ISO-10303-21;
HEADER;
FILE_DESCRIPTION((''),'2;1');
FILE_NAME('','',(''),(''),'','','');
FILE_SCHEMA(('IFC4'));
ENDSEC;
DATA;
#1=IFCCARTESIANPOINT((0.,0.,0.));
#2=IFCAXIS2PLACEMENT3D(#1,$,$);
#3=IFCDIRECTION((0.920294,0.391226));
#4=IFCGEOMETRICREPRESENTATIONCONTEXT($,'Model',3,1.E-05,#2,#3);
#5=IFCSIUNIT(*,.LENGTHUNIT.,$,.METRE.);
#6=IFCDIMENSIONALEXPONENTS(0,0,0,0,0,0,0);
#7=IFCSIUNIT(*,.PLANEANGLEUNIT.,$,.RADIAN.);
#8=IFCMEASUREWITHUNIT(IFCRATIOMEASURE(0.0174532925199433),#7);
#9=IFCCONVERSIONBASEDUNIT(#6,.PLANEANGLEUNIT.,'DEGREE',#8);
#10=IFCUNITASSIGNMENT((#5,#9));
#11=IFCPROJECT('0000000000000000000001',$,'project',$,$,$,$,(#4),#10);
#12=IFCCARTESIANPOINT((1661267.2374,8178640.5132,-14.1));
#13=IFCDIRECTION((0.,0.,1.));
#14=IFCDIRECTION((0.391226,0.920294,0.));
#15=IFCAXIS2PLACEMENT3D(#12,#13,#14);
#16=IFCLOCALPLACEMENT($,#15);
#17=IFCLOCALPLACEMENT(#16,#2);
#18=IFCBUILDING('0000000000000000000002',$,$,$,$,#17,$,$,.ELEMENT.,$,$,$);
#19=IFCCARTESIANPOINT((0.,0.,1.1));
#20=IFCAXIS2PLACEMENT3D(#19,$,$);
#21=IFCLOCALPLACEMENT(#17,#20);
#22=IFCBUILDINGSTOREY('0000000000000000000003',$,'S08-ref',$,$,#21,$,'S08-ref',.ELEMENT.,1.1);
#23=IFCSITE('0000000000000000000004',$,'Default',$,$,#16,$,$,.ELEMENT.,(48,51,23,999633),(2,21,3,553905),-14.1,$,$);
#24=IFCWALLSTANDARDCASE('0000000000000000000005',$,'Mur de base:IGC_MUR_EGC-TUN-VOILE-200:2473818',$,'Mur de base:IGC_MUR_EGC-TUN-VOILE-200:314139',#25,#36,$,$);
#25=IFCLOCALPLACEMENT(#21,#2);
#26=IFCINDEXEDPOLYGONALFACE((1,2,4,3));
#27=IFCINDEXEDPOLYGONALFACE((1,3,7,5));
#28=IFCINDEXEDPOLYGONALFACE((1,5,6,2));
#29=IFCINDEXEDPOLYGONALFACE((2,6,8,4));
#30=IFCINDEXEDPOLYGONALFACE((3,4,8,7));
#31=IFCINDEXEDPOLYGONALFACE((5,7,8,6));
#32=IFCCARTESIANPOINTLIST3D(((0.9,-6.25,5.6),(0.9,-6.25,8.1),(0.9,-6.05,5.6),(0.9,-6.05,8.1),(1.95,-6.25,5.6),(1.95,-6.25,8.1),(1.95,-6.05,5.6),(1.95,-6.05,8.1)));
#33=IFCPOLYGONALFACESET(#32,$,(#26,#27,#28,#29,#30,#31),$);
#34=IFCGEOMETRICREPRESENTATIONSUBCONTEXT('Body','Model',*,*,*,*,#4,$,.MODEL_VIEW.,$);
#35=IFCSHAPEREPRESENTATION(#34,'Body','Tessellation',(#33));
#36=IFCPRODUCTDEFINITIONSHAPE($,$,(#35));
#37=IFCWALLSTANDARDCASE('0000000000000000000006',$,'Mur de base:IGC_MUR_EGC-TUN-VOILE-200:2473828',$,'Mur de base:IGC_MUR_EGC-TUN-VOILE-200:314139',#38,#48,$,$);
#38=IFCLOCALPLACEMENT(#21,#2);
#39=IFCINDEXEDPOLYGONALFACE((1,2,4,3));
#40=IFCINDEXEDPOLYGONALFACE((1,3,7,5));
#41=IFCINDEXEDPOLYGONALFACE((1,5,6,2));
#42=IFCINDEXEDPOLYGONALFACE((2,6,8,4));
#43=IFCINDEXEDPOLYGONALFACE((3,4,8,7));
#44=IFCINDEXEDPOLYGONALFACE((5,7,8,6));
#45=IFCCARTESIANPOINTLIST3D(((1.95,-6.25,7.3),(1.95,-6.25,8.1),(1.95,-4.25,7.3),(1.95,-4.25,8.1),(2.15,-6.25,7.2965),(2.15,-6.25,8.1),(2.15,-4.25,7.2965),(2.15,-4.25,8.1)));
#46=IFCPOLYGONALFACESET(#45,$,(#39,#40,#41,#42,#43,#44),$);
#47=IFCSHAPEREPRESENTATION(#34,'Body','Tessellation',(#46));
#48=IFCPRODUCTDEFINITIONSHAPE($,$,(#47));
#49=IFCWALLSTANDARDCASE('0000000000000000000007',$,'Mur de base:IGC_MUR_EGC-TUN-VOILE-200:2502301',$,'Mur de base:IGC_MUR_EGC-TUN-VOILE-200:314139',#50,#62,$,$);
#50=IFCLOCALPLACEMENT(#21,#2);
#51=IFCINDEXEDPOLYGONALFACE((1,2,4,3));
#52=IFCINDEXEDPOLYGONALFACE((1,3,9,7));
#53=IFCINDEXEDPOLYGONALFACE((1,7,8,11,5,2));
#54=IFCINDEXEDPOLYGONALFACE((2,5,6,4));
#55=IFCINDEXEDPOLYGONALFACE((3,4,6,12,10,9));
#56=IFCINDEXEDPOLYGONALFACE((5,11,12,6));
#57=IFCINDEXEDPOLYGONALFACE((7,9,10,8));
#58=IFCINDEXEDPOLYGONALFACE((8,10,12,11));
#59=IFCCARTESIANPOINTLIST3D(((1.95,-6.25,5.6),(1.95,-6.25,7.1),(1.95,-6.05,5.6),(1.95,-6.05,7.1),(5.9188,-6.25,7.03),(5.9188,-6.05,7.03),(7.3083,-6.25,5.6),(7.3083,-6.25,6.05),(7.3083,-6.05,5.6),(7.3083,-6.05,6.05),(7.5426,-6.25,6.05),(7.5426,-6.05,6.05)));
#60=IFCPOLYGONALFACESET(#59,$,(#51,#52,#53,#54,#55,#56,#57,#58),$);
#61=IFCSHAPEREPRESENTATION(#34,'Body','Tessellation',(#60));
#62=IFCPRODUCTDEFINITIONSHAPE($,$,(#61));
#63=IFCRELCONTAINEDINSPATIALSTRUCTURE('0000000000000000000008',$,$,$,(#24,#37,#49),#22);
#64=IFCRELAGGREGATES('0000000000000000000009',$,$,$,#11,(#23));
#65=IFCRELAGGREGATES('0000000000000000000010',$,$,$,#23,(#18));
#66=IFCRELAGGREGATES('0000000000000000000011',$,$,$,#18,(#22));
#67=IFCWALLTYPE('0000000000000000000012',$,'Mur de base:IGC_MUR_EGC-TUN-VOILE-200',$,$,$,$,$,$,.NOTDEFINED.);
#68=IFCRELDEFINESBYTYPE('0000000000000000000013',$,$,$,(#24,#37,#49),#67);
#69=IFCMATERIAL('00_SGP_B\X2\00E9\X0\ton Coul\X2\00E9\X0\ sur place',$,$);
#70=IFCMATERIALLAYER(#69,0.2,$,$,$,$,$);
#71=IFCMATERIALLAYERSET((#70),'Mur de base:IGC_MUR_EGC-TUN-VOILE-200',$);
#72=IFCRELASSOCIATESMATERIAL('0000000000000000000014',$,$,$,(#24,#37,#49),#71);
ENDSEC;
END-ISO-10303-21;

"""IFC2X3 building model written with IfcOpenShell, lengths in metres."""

from ifc_helpers import new_model, entity, si_unit, converted_unit, direction, frame, frame_2d, origin, place, context, subcontext, project, spatial, polyline, rectangle, extrude, clip, halfspace, bounded_halfspace, material, layer, layer_set, layer_usage, type_object, element, save


model = new_model("IFC2X3")

# Units and contexts
model_context = context("Model", 3, precision=1e-05, world=origin(), true_north=direction((0.920294, 0.391226)))
body_context = subcontext(model_context, "Body", "Model", "MODEL_VIEW")
ifc_project = project(units=[si_unit("LENGTHUNIT", "METRE"), converted_unit("PLANEANGLEUNIT", "DEGREE", entity("IfcRatioMeasure", 0.0174532925199433), si_unit("PLANEANGLEUNIT", "RADIAN"), dimensions=[0, 0, 0, 0, 0, 0, 0])], contexts=[model_context])

# Site, building, storey
site_placement = place(None, frame((1661267.2374, 8178640.5132, -14.1), z_axis=(0.0, 0.0, 1.0), x_axis=(0.391226, 0.920294, 0.0)))
site = spatial("IfcSite", under=ifc_project, at=site_placement, Name="Default", CompositionType="ELEMENT", RefLatitude=(48, 51, 23, 999633), RefLongitude=(2, 21, 3, 553905), RefElevation=-14.1)
building_placement = place(site_placement, origin())
building = spatial("IfcBuilding", under=site, at=building_placement, CompositionType="ELEMENT")
storey_placement = place(building_placement, frame((0.0, 0.0, 1.1)))
storey = spatial("IfcBuildingStorey", under=building, at=storey_placement, Name="S08-ref", LongName="S08-ref", CompositionType="ELEMENT", Elevation=1.1)

# Walls
ifc_material_1 = material(Name="00_SGP_Béton Coulé sur place")
ifc_layer_1 = layer(ifc_material_1, 0.2)
ifc_layer_set_1 = layer_set([ifc_layer_1], Name="Mur de base:IGC_MUR_EGC-TUN-VOILE-200")
ifc_layer_usage_1 = layer_usage(ifc_layer_set_1, "AXIS2", "NEGATIVE", 0.1)
wall_type_1 = type_object("IfcWallType", Name="Mur de base:IGC_MUR_EGC-TUN-VOILE-200", PredefinedType="NOTDEFINED")
wall_1_placement = place(storey_placement, frame((0.9, -6.15, 5.6)))
element("IfcWallStandardCase", 1, at=wall_1_placement, inside=storey, type_object=wall_type_1, material=ifc_layer_usage_1, Name="Mur de base:IGC_MUR_EGC-TUN-VOILE-200:2473818", ObjectType="Mur de base:IGC_MUR_EGC-TUN-VOILE-200:314139", context=body_context, shape_type="SweptSolid", body=[
    extrude(rectangle(XDim=1.05, YDim=0.2, at=frame_2d((0.525, 0.0), x_axis=(-1.0, 0.0))), origin(), (0.0, 0.0, 1.0), 2.5),
])
ifc_layer_usage_2 = layer_usage(ifc_layer_set_1, "AXIS2", "NEGATIVE", 0.1)
wall_2_placement = place(storey_placement, frame((2.05, -6.25, 7.2965), z_axis=(0.0, 0.0, 1.0), x_axis=(0.0, 1.0, 0.0)))
element("IfcWallStandardCase", 2, at=wall_2_placement, inside=storey, type_object=wall_type_1, material=ifc_layer_usage_2, Name="Mur de base:IGC_MUR_EGC-TUN-VOILE-200:2473828", ObjectType="Mur de base:IGC_MUR_EGC-TUN-VOILE-200:314139", context=body_context, shape_type="Clipping", body=[
    clip(clip(extrude(rectangle(XDim=2.0, YDim=0.2, at=frame_2d((1.0, 0.0), x_axis=(-1.0, 0.0))), origin(), (0.0, 0.0, 1.0), 0.8035), bounded_halfspace(frame((2.0, -0.1, 0.0), z_axis=(0.0, -0.017635, 0.999844), x_axis=(0.0, 0.999844, 0.017635)), True, frame((2.0, -0.1, 0.0), z_axis=(0.0, -0.017635, 0.999844), x_axis=(0.0, 0.999844, 0.017635)), polyline([(0.0, 0.0), (0.2, 0.0), (0.2, 2.0), (0.0, 2.0), (0.0, 0.0)]))), bounded_halfspace(frame((0.0, -0.1, 0.8035), z_axis=(0.0, 0.0, -1.0), x_axis=(-1.0, 0.0, 0.0)), True, frame((0.0, -0.1, 0.8035), z_axis=(0.0, 0.0, -1.0), x_axis=(-1.0, 0.0, 0.0)), polyline([(0.0, 0.0), (0.0, 0.2), (-0.2, 0.2), (-2.0, 0.2), (-2.0, 0.0), (-1.8, 0.0), (0.0, 0.0)]))),
])
ifc_layer_usage_3 = layer_usage(ifc_layer_set_1, "AXIS2", "NEGATIVE", 0.1)
wall_3_placement = place(storey_placement, frame((1.95, -6.15, 5.6)))
element("IfcWallStandardCase", 3, at=wall_3_placement, inside=storey, type_object=wall_type_1, material=ifc_layer_usage_3, Name="Mur de base:IGC_MUR_EGC-TUN-VOILE-200:2502301", ObjectType="Mur de base:IGC_MUR_EGC-TUN-VOILE-200:314139", context=body_context, shape_type="Clipping", body=[
    clip(clip(clip(clip(extrude(rectangle(XDim=5.5926, YDim=0.2, at=frame_2d((2.7963, 0.0), x_axis=(-1.0, 0.0))), origin(), (0.0, 0.0, 1.0), 1.5), bounded_halfspace(frame((5.3583, 0.1, 0.45), z_axis=(-1.0, 0.0, 0.0), x_axis=(0.0, 1.0, 0.0)), True, frame((5.3583, 0.1, 0.45), z_axis=(-1.0, 0.0, 0.0), x_axis=(0.0, 1.0, 0.0)), polyline([(0.0, 0.0), (0.0, 0.45), (-0.2, 0.45), (-0.2, 0.0), (0.0, 0.0)]))), bounded_halfspace(frame((5.3583, -0.1, 0.45), z_axis=(0.0, 0.0, 1.0), x_axis=(0.0, 1.0, 0.0)), True, frame((5.3583, -0.1, 0.45), z_axis=(0.0, 0.0, 1.0), x_axis=(0.0, 1.0, 0.0)), polyline([(0.0, 0.0), (0.0, -0.2343), (0.2, -0.2343), (0.2, 0.0), (0.0, 0.0)]))), halfspace(frame((0.0, -0.1, 1.5), z_axis=(0.017635, 0.0, 0.999844), x_axis=(0.0, 1.0, 0.0)), False)), halfspace(frame((3.9688, 0.1, 1.43), z_axis=(0.516703, 0.0, 0.856165), x_axis=(0.0, 1.0, 0.0)), False)),
])

save(model, "model.ifc")
